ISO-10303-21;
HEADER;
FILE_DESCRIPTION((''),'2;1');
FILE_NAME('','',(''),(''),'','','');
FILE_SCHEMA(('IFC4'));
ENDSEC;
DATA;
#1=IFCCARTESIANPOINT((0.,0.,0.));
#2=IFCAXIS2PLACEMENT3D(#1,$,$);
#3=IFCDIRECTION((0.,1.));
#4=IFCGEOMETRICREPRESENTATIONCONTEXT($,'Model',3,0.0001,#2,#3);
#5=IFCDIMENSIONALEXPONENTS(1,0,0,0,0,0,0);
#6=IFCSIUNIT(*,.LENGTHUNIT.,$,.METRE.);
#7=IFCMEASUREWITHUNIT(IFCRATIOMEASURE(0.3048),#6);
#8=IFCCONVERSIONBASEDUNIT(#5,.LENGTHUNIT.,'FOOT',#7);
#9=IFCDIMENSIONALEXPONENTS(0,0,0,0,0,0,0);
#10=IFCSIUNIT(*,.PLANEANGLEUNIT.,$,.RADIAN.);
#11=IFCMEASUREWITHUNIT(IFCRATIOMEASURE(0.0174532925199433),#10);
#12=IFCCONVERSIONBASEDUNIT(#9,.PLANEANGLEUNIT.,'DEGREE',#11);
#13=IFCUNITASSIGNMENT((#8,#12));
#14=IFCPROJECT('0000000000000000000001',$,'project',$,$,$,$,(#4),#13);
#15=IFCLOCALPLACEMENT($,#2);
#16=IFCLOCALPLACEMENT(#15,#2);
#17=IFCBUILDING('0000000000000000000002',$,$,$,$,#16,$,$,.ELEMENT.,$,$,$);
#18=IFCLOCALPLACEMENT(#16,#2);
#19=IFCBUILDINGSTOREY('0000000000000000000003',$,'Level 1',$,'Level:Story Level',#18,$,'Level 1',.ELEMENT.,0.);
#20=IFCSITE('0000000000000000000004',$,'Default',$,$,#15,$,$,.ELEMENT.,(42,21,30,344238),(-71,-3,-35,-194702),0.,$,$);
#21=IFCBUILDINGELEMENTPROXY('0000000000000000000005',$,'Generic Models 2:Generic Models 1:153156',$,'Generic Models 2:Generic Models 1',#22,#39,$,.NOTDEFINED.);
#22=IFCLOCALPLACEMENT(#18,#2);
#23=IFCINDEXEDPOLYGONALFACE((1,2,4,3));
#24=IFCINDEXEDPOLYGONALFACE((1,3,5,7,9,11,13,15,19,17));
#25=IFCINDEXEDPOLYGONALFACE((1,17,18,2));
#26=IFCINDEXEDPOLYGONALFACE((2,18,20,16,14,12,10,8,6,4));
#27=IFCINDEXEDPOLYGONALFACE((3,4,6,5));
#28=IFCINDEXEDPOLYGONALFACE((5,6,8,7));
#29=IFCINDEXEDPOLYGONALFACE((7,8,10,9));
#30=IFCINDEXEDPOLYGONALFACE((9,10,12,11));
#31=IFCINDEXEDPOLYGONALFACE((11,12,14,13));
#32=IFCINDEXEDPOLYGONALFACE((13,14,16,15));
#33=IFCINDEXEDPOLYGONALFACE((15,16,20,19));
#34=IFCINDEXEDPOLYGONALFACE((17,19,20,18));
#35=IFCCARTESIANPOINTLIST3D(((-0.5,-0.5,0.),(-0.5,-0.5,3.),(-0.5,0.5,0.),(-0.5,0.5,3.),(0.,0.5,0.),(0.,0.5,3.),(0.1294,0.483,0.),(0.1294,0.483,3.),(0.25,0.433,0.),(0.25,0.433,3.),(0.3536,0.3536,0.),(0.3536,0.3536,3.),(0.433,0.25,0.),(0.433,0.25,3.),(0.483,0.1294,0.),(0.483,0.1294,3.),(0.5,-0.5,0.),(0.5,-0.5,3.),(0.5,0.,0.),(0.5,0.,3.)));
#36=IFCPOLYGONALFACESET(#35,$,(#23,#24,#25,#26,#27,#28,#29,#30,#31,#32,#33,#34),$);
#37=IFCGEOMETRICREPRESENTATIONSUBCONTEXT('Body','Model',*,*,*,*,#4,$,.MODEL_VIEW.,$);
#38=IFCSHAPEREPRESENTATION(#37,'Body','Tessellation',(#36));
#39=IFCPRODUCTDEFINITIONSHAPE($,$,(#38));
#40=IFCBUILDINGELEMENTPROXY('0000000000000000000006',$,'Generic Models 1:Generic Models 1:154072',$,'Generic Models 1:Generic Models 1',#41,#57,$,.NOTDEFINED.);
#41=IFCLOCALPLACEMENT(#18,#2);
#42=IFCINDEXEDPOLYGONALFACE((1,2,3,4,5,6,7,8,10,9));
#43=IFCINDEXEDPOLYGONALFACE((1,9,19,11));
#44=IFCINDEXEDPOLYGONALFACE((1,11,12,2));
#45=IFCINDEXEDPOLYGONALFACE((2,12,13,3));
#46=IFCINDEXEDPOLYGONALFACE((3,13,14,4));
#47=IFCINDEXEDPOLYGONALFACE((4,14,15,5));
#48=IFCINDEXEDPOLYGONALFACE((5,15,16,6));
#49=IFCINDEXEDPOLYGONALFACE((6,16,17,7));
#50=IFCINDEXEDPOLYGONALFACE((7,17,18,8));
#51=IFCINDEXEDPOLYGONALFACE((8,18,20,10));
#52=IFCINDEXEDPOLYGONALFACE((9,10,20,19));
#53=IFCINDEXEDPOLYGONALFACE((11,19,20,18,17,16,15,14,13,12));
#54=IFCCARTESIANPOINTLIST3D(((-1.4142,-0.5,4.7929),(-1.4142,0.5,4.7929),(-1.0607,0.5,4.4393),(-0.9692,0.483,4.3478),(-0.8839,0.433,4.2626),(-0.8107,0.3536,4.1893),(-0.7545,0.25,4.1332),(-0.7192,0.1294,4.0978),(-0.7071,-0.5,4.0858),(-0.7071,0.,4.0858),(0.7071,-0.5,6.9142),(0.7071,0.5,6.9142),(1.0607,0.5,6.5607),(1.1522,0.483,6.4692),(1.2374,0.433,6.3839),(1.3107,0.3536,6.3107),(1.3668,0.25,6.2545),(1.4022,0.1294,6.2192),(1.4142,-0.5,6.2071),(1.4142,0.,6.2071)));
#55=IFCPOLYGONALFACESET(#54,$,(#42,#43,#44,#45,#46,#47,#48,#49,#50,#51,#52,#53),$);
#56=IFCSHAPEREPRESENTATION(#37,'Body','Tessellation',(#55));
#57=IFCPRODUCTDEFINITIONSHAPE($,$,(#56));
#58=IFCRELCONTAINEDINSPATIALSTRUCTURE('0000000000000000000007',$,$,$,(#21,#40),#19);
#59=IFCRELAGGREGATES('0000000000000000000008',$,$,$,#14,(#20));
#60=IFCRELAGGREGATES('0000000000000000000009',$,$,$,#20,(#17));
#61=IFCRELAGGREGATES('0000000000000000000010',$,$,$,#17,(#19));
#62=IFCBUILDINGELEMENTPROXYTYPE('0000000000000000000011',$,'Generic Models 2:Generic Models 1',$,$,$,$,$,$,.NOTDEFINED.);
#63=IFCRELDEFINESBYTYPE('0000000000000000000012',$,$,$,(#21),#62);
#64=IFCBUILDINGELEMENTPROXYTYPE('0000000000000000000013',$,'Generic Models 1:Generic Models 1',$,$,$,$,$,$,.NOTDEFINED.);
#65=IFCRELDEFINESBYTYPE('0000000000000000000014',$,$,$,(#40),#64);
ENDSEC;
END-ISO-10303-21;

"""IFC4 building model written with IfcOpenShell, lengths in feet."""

from ifc_helpers import new_model, entity, si_unit, converted_unit, direction, frame, frame_2d, origin, place, context, subcontext, project, spatial, polyline, circle_curve, parameter, trimmed, segment, composite_curve, outline, extrude, source, transform, mapped, type_object, type_shapes, element, save


model = new_model("IFC4")

# Units and contexts
model_context = context("Model", 3, precision=0.0001, world=origin(), true_north=direction((0.0, 1.0)))
body_context = subcontext(model_context, "Body", "Model", "MODEL_VIEW")
ifc_project = project(units=[converted_unit("LENGTHUNIT", "FOOT", entity("IfcRatioMeasure", 0.3048), si_unit("LENGTHUNIT", "METRE"), dimensions=[1, 0, 0, 0, 0, 0, 0]), converted_unit("PLANEANGLEUNIT", "DEGREE", entity("IfcRatioMeasure", 0.0174532925199433), si_unit("PLANEANGLEUNIT", "RADIAN"), dimensions=[0, 0, 0, 0, 0, 0, 0])], contexts=[model_context])

# Site, building, storey
site_placement = place(None, origin())
site = spatial("IfcSite", under=ifc_project, at=site_placement, Name="Default", CompositionType="ELEMENT", RefLatitude=(42, 21, 30, 344238), RefLongitude=(-71, -3, -35, -194702), RefElevation=0.0)
building_placement = place(site_placement, origin())
building = spatial("IfcBuilding", under=site, at=building_placement, CompositionType="ELEMENT")
storey_placement = place(building_placement, origin())
storey = spatial("IfcBuildingStorey", under=building, at=storey_placement, Name="Level 1", ObjectType="Level:Story Level", LongName="Level 1", CompositionType="ELEMENT", Elevation=0.0)

# Building element proxies
building_element_proxy_type_1 = type_object("IfcBuildingElementProxyType", Name="Generic Models 2:Generic Models 1", PredefinedType="NOTDEFINED")
shared_shape_1 = source(origin(), body_context, "Body", "SweptSolid", [
    extrude(outline(composite_curve([segment(polyline([(-0.5, -0.5), (0.5, -0.5)]), True, "CONTINUOUS"), segment(polyline([(0.5, -0.5), (0.5, 0.5)]), True, "CONTINUOUS"), segment(polyline([(0.5, 0.5), (0.0, 0.5)]), True, "CONTINUOUS"), segment(trimmed(circle_curve(frame_2d((0.0, 0.0), x_axis=(0.0, 1.0)), 0.5), [parameter(360.0)], [parameter(90.0)], True, "PARAMETER"), True, "CONTINUOUS"), segment(polyline([(-0.5, 0.0), (-0.5, -0.5)]), True, "CONTINUOUS")], self_intersect=False)), frame((0.0, 0.0, 0.0), z_axis=(0.0, 0.0, 1.0), x_axis=(0.0, -1.0, 0.0)), (0.0, 0.0, 1.0), 3.0),
])
type_shapes(building_element_proxy_type_1, [shared_shape_1])
proxy_1_placement = place(storey_placement, origin())
element("IfcBuildingElementProxy", 1, at=proxy_1_placement, inside=storey, type_object=building_element_proxy_type_1, Name="Generic Models 2:Generic Models 1:153156", ObjectType="Generic Models 2:Generic Models 1", PredefinedType="NOTDEFINED", context=body_context, shape_type="MappedRepresentation", body=[
    mapped(shared_shape_1, transform((0.0, 0.0, 0.0), scale=1.0)),
])
building_element_proxy_type_2 = type_object("IfcBuildingElementProxyType", Name="Generic Models 1:Generic Models 1", PredefinedType="NOTDEFINED")
shared_shape_2 = source(origin(), body_context, "Body", "SweptSolid", [
    extrude(outline(composite_curve([segment(polyline([(-0.5, -0.5), (0.5, -0.5)]), True, "CONTINUOUS"), segment(polyline([(0.5, -0.5), (0.5, 0.5)]), True, "CONTINUOUS"), segment(polyline([(0.5, 0.5), (0.0, 0.5)]), True, "CONTINUOUS"), segment(trimmed(circle_curve(frame_2d((0.0, 0.0), x_axis=(0.0, 1.0)), 0.5), [parameter(360.0)], [parameter(90.0)], True, "PARAMETER"), True, "CONTINUOUS"), segment(polyline([(-0.5, 0.0), (-0.5, -0.5)]), True, "CONTINUOUS")], self_intersect=False)), frame((0.3536, 0.5, 0.3588), z_axis=(0.707107, 0.0, 0.707107), x_axis=(0.0, -1.0, 0.0)), (0.0, 0.0, 1.0), 3.0),
])
type_shapes(building_element_proxy_type_2, [shared_shape_2])
proxy_2_placement = place(storey_placement, frame((-1.4142, -0.5, 4.0806)))
element("IfcBuildingElementProxy", 2, at=proxy_2_placement, inside=storey, type_object=building_element_proxy_type_2, Name="Generic Models 1:Generic Models 1:154072", ObjectType="Generic Models 1:Generic Models 1", PredefinedType="NOTDEFINED", context=body_context, shape_type="MappedRepresentation", body=[
    mapped(shared_shape_2, transform((0.0, 0.0, 0.0), scale=1.0)),
])

save(model, "model.ifc")
